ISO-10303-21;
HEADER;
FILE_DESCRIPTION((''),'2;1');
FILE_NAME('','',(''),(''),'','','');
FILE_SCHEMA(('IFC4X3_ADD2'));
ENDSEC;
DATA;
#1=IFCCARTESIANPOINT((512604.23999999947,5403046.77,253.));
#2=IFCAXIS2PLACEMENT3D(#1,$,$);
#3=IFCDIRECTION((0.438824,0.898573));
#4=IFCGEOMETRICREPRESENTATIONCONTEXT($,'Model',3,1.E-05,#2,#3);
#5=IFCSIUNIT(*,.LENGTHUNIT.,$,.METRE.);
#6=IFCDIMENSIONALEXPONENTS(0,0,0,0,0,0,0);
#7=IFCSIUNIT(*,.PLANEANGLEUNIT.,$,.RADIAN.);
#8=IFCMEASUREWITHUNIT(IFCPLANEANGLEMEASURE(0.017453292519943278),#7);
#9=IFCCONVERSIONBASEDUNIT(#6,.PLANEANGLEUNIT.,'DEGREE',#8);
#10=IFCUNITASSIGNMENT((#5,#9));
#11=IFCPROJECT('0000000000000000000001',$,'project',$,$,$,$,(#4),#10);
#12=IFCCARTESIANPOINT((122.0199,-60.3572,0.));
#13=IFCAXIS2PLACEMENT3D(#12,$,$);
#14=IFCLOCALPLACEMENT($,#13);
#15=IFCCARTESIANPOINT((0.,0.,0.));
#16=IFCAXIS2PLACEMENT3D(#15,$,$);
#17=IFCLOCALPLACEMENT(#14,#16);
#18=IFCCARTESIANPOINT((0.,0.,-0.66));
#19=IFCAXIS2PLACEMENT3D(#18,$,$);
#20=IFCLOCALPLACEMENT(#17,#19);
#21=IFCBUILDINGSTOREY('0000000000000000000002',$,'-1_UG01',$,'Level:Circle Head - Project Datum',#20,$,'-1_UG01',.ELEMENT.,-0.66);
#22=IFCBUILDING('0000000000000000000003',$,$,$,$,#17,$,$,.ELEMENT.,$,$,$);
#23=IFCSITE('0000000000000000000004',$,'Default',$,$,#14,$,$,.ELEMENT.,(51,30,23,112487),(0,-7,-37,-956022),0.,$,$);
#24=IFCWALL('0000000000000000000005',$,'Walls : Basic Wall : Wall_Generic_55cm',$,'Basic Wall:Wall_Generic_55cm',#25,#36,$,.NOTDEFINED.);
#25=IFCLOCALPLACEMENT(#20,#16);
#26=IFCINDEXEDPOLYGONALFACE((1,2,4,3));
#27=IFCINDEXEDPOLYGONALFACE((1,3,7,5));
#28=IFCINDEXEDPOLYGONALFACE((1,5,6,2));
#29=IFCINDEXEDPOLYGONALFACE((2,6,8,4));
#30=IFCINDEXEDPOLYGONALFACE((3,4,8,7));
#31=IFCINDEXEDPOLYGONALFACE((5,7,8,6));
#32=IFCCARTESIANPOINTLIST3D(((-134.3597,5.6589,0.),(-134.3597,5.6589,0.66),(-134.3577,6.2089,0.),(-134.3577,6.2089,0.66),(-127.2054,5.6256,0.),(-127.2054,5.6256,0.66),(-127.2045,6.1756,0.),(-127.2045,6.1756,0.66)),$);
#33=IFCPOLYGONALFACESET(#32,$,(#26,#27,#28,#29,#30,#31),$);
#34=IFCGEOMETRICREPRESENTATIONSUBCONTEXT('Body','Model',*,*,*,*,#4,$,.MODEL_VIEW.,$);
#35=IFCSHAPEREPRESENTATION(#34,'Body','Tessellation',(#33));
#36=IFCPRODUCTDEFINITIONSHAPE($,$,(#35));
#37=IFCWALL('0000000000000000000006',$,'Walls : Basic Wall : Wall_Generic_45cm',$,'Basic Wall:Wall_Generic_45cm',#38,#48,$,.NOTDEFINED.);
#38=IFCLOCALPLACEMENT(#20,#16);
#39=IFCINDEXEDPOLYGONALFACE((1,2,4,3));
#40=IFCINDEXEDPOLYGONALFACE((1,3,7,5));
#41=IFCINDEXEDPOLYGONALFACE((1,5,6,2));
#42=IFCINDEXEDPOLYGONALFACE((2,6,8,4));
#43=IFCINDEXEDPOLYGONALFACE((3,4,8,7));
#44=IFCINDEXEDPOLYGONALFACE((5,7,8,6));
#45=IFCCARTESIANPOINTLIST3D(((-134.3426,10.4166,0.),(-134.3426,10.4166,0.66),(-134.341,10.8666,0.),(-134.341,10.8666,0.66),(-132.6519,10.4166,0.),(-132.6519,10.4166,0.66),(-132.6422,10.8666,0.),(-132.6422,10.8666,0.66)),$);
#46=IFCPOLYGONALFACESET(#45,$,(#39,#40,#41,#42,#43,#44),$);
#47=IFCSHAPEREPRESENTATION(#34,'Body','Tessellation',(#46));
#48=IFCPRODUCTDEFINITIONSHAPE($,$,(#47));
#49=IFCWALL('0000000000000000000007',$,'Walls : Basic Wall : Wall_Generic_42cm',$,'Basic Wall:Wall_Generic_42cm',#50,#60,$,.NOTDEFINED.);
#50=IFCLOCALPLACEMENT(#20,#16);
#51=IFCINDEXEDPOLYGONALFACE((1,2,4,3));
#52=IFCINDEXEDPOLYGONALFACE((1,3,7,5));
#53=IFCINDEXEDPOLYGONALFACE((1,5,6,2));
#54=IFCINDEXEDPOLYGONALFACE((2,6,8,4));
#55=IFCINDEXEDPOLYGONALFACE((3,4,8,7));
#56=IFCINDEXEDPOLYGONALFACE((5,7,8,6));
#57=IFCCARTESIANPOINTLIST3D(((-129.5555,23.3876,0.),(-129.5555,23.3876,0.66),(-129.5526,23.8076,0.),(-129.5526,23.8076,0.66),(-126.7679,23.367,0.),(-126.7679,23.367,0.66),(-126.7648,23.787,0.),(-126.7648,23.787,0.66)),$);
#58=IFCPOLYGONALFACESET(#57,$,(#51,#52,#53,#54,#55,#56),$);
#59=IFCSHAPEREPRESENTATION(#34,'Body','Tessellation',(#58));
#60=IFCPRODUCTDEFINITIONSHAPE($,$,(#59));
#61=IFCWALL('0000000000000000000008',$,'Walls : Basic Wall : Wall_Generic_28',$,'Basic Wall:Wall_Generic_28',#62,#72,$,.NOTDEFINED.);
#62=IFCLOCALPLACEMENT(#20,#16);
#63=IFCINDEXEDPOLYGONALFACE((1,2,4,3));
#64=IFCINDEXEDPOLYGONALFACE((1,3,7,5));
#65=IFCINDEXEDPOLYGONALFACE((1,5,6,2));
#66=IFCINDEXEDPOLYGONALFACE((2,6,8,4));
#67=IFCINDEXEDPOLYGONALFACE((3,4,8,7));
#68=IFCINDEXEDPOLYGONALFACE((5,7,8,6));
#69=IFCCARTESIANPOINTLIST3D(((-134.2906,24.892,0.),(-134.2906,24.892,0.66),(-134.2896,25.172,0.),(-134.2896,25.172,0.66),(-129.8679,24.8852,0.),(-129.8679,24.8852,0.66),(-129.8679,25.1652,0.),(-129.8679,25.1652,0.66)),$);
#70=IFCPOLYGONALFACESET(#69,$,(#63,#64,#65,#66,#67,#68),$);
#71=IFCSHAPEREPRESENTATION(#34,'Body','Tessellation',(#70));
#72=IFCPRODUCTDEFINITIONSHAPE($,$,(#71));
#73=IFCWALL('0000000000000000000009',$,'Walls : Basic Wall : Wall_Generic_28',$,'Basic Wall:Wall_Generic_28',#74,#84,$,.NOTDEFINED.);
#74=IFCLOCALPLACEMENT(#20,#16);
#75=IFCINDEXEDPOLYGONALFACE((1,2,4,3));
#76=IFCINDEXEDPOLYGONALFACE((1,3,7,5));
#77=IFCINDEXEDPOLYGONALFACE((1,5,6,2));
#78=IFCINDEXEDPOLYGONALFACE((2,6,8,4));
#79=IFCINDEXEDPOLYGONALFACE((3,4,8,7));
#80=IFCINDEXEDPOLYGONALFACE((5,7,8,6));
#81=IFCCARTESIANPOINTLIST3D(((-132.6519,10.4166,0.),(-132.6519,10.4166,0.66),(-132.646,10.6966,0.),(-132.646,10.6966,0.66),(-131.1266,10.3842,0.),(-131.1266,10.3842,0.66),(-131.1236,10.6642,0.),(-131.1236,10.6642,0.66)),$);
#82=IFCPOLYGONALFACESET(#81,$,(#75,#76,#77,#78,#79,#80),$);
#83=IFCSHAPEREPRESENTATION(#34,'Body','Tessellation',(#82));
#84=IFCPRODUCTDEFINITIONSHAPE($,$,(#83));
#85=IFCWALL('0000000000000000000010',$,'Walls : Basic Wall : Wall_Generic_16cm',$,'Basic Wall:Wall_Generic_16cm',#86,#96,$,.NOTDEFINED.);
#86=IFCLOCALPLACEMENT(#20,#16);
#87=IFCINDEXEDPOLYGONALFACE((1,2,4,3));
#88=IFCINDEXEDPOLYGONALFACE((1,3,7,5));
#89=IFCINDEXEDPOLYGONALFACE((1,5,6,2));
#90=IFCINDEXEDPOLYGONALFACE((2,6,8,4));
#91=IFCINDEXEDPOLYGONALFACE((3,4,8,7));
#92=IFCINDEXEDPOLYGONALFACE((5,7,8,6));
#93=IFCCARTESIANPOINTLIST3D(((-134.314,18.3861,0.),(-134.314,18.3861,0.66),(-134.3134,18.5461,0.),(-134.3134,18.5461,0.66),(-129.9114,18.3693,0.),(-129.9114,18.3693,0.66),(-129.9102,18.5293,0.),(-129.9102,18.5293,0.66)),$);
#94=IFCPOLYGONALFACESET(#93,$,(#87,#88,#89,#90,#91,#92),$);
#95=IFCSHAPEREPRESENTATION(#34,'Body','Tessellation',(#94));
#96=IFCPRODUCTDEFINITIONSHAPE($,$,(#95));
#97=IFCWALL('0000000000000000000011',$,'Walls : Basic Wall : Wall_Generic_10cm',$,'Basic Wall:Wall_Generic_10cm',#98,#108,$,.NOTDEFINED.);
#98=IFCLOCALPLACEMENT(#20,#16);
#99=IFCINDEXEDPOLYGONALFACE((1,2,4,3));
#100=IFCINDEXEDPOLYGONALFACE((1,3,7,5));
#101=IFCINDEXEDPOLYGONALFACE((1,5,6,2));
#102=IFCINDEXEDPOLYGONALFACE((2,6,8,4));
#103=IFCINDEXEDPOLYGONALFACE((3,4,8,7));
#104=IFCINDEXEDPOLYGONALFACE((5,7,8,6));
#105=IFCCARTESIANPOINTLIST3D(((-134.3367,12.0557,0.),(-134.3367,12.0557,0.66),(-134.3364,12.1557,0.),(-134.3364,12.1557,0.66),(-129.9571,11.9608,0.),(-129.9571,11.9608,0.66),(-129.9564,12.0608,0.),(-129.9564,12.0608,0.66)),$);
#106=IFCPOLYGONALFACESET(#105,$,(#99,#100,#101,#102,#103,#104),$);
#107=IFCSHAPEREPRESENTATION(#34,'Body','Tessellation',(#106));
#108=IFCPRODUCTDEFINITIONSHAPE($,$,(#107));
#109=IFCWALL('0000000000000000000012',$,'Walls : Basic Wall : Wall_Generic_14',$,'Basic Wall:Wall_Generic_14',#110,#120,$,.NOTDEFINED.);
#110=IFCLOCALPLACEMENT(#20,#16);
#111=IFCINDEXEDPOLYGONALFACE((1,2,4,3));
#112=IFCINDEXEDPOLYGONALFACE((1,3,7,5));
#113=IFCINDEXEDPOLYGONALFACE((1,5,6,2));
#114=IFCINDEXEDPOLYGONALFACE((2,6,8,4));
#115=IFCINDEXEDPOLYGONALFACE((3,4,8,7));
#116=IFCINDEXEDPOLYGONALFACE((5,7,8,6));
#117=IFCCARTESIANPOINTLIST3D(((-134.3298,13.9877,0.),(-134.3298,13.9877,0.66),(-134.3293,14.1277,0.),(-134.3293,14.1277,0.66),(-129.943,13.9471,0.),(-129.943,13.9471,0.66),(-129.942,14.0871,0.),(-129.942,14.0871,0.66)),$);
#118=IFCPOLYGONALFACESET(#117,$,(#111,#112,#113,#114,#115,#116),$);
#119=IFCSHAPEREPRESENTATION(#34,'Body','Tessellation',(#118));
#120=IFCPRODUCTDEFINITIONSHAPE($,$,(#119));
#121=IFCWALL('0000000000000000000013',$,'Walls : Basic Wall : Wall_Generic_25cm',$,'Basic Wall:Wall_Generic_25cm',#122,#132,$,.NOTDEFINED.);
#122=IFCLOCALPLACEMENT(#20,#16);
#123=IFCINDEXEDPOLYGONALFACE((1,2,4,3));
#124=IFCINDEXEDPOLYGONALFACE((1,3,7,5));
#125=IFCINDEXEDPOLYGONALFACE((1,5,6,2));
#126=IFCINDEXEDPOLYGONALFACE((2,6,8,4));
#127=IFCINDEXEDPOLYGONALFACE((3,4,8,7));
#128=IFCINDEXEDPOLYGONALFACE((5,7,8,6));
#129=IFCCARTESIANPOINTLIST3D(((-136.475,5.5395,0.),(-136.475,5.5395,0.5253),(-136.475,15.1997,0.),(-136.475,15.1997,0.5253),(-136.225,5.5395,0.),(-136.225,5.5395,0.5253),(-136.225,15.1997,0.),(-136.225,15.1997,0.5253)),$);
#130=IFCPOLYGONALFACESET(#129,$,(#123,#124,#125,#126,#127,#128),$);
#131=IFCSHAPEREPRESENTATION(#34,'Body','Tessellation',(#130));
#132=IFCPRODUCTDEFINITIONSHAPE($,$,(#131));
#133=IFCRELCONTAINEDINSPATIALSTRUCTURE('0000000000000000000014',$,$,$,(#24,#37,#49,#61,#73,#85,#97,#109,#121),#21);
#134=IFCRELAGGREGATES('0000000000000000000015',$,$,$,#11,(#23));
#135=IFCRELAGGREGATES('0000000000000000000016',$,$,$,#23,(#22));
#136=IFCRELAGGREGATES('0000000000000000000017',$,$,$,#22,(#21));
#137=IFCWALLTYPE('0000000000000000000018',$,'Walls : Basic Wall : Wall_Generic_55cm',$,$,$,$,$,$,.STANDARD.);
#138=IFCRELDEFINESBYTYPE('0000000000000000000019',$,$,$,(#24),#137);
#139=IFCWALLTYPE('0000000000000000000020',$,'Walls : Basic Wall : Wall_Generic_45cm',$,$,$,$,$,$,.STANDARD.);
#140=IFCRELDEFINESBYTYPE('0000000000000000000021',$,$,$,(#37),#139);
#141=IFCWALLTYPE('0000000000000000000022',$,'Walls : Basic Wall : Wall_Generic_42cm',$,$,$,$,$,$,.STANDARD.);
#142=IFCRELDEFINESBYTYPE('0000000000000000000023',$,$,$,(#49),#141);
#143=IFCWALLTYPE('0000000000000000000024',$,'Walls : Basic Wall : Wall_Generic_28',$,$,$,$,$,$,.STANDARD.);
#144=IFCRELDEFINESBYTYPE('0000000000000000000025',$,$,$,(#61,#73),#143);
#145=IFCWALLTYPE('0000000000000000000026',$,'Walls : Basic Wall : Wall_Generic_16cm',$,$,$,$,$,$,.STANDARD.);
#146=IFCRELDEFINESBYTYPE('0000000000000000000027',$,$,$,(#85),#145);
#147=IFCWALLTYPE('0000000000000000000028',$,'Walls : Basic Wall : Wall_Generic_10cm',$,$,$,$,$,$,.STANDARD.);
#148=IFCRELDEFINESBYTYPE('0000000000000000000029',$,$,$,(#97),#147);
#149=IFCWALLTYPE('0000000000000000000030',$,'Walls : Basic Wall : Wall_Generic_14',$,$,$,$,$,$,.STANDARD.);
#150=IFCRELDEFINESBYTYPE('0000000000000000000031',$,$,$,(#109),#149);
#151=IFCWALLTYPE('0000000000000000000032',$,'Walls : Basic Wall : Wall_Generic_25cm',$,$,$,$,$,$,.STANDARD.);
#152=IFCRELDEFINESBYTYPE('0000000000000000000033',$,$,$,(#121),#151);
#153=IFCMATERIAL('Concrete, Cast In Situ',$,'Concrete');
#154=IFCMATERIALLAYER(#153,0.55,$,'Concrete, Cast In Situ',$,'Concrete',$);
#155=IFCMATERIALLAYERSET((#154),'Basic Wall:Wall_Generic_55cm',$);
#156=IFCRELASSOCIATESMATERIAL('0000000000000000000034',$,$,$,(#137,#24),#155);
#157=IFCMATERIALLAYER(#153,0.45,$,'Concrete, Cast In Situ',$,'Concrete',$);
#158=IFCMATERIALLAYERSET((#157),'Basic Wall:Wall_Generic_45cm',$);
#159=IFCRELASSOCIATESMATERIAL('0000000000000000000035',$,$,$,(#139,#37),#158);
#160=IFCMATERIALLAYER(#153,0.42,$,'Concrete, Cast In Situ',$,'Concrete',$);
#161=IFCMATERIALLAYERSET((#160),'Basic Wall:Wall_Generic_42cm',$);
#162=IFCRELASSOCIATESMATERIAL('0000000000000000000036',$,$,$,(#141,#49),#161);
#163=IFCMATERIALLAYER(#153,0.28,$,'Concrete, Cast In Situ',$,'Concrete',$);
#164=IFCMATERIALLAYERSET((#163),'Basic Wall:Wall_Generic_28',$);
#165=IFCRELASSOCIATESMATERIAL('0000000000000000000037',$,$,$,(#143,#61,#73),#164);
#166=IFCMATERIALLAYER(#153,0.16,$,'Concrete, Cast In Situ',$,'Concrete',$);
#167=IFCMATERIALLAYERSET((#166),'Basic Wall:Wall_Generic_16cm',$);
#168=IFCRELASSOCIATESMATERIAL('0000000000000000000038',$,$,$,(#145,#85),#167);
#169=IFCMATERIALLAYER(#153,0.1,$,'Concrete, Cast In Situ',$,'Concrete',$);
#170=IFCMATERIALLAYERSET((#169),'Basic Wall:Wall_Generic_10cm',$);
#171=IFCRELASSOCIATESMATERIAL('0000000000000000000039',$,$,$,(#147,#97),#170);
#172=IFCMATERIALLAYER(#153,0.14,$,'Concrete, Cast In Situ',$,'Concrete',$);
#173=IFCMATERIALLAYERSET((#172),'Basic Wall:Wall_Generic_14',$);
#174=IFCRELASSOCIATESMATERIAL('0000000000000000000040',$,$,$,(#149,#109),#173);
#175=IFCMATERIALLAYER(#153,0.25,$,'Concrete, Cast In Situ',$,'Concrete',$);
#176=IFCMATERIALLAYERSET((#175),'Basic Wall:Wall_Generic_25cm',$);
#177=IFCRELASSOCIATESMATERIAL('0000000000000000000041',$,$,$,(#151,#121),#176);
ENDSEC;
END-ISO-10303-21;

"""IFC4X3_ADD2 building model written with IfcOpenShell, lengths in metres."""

from ifc_helpers import new_model, entity, si_unit, converted_unit, direction, frame, frame_2d, origin, place, context, subcontext, project, spatial, polyline, rectangle, outline, extrude, clip, halfspace, material, layer, layer_set, type_object, element, save


model = new_model("IFC4X3_ADD2")

# Units and contexts
model_context = context("Model", 3, precision=1e-05, world=frame((512604.23999999947, 5403046.77, 253.0)), true_north=direction((0.438824, 0.898573)))
body_context = subcontext(model_context, "Body", "Model", "MODEL_VIEW")
ifc_project = project(units=[si_unit("LENGTHUNIT", "METRE"), converted_unit("PLANEANGLEUNIT", "DEGREE", entity("IfcPlaneAngleMeasure", 0.017453292519943278), si_unit("PLANEANGLEUNIT", "RADIAN"), dimensions=[0, 0, 0, 0, 0, 0, 0])], contexts=[model_context])

# Site, building, storey
site_placement = place(None, frame((122.0199, -60.3572, 0.0)))
site = spatial("IfcSite", under=ifc_project, at=site_placement, Name="Default", CompositionType="ELEMENT", RefLatitude=(51, 30, 23, 112487), RefLongitude=(0, -7, -37, -956022), RefElevation=0.0)
building_placement = place(site_placement, origin())
building = spatial("IfcBuilding", under=site, at=building_placement, CompositionType="ELEMENT")
storey_placement = place(building_placement, frame((0.0, 0.0, -0.66)))
storey = spatial("IfcBuildingStorey", under=building, at=storey_placement, Name="-1_UG01", ObjectType="Level:Circle Head - Project Datum", LongName="-1_UG01", CompositionType="ELEMENT", Elevation=-0.66)

# Walls
ifc_material_1 = material(Name="Concrete, Cast In Situ", Category="Concrete")
ifc_layer_1 = layer(ifc_material_1, 0.55, Name="Concrete, Cast In Situ", Category="Concrete")
ifc_layer_set_1 = layer_set([ifc_layer_1], Name="Basic Wall:Wall_Generic_55cm")
wall_type_1 = type_object("IfcWallType", Name="Walls : Basic Wall : Wall_Generic_55cm", PredefinedType="STANDARD", material=ifc_layer_set_1)
wall_1_placement = place(storey_placement, frame((-134.359, 5.9339, 0.0), z_axis=(0.0, 0.0, 1.0), x_axis=(0.999989, -0.004647, 0.0)))
element("IfcWall", 1, at=wall_1_placement, inside=storey, type_object=wall_type_1, material=ifc_layer_set_1, Name="Walls : Basic Wall : Wall_Generic_55cm", ObjectType="Basic Wall:Wall_Generic_55cm", PredefinedType="NOTDEFINED", context=body_context, shape_type="Clipping", body=[
    clip(extrude(outline(polyline([(7.155, -0.275), (7.1533, 0.275), (0.0, 0.275), (0.0006, -0.275), (7.155, -0.275)])), origin(), (0.0, 0.0, 1.0), 0.66), halfspace(origin(), True)),
])
ifc_layer_2 = layer(ifc_material_1, 0.45, Name="Concrete, Cast In Situ", Category="Concrete")
ifc_layer_set_2 = layer_set([ifc_layer_2], Name="Basic Wall:Wall_Generic_45cm")
wall_type_2 = type_object("IfcWallType", Name="Walls : Basic Wall : Wall_Generic_45cm", PredefinedType="STANDARD", material=ifc_layer_set_2)
wall_2_placement = place(storey_placement, frame((-134.3426, 10.6416, 0.0)))
element("IfcWall", 2, at=wall_2_placement, inside=storey, type_object=wall_type_2, material=ifc_layer_set_2, Name="Walls : Basic Wall : Wall_Generic_45cm", ObjectType="Basic Wall:Wall_Generic_45cm", PredefinedType="NOTDEFINED", context=body_context, shape_type="Clipping", body=[
    clip(extrude(outline(polyline([(1.6907, -0.225), (1.6968, 0.0549), (1.7004, 0.225), (1.6604, 0.225), (0.0016, 0.225), (0.0, -0.225), (1.6327, -0.225), (1.6727, -0.225), (1.6907, -0.225)])), origin(), (0.0, 0.0, 1.0), 0.66), halfspace(origin(), True)),
])
ifc_layer_3 = layer(ifc_material_1, 0.42, Name="Concrete, Cast In Situ", Category="Concrete")
ifc_layer_set_3 = layer_set([ifc_layer_3], Name="Basic Wall:Wall_Generic_42cm")
wall_type_3 = type_object("IfcWallType", Name="Walls : Basic Wall : Wall_Generic_42cm", PredefinedType="STANDARD", material=ifc_layer_set_3)
wall_3_placement = place(storey_placement, frame((-129.5541, 23.5976, 0.0), z_axis=(0.0, 0.0, 1.0), x_axis=(0.999973, -0.007398, 0.0)))
element("IfcWall", 3, at=wall_3_placement, inside=storey, type_object=wall_type_3, material=ifc_layer_set_3, Name="Walls : Basic Wall : Wall_Generic_42cm", ObjectType="Basic Wall:Wall_Generic_42cm", PredefinedType="NOTDEFINED", context=body_context, shape_type="Clipping", body=[
    clip(extrude(outline(polyline([(2.7879, -0.21), (2.7879, 0.21), (2.309, 0.21), (0.0, 0.21), (0.0001, -0.21), (2.3679, -0.21), (2.7879, -0.21)])), origin(), (0.0, 0.0, 1.0), 0.66), halfspace(origin(), True)),
])
ifc_layer_4 = layer(ifc_material_1, 0.28, Name="Concrete, Cast In Situ", Category="Concrete")
ifc_layer_set_4 = layer_set([ifc_layer_4], Name="Basic Wall:Wall_Generic_28")
wall_type_4 = type_object("IfcWallType", Name="Walls : Basic Wall : Wall_Generic_28", PredefinedType="STANDARD", material=ifc_layer_set_4)
wall_4_placement = place(storey_placement, frame((-134.2904, 25.032, 0.0), z_axis=(0.0, 0.0, 1.0), x_axis=(0.999999, -0.001547, 0.0)))
element("IfcWall", 4, at=wall_4_placement, inside=storey, type_object=wall_type_4, material=ifc_layer_set_4, Name="Walls : Basic Wall : Wall_Generic_28", ObjectType="Basic Wall:Wall_Generic_28", PredefinedType="NOTDEFINED", context=body_context, shape_type="Clipping", body=[
    clip(extrude(outline(polyline([(4.4228, -0.14), (4.4223, 0.14), (4.342, 0.14), (0.0006, 0.14), (0.0, -0.14), (4.4228, -0.14)])), origin(), (0.0, 0.0, 1.0), 0.66), halfspace(origin(), True)),
])
wall_5_placement = place(storey_placement, frame((-132.6489, 10.5566, 0.0), z_axis=(0.0, 0.0, 1.0), x_axis=(0.999774, -0.021241, 0.0)))
element("IfcWall", 5, at=wall_5_placement, inside=storey, type_object=wall_type_4, material=ifc_layer_set_4, Name="Walls : Basic Wall : Wall_Generic_28", ObjectType="Basic Wall:Wall_Generic_28", PredefinedType="NOTDEFINED", context=body_context, shape_type="Clipping", body=[
    clip(extrude(outline(polyline([(1.5256, -0.14), (1.5227, 0.14), (0.0, 0.14), (0.0, -0.14), (1.5256, -0.14)])), origin(), (0.0, 0.0, 1.0), 0.66), halfspace(origin(), True)),
])
ifc_layer_5 = layer(ifc_material_1, 0.16, Name="Concrete, Cast In Situ", Category="Concrete")
ifc_layer_set_5 = layer_set([ifc_layer_5], Name="Basic Wall:Wall_Generic_16cm")
wall_type_5 = type_object("IfcWallType", Name="Walls : Basic Wall : Wall_Generic_16cm", PredefinedType="STANDARD", material=ifc_layer_set_5)
wall_6_placement = place(storey_placement, frame((-129.9105, 18.4493, 0.0), z_axis=(0.0, 0.0, 1.0), x_axis=(-0.999993, 0.003818, 0.0)))
element("IfcWall", 6, at=wall_6_placement, inside=storey, type_object=wall_type_5, material=ifc_layer_set_5, Name="Walls : Basic Wall : Wall_Generic_16cm", ObjectType="Basic Wall:Wall_Generic_16cm", PredefinedType="NOTDEFINED", context=body_context, shape_type="Clipping", body=[
    clip(extrude(outline(polyline([(4.4032, -0.08), (4.4032, 0.08), (0.0005, 0.08), (0.0, -0.08), (4.4032, -0.08)])), origin(), (0.0, 0.0, 1.0), 0.66), halfspace(origin(), True)),
])
ifc_layer_6 = layer(ifc_material_1, 0.1, Name="Concrete, Cast In Situ", Category="Concrete")
ifc_layer_set_6 = layer_set([ifc_layer_6], Name="Basic Wall:Wall_Generic_10cm")
wall_type_6 = type_object("IfcWallType", Name="Walls : Basic Wall : Wall_Generic_10cm", PredefinedType="STANDARD", material=ifc_layer_set_6)
wall_7_placement = place(storey_placement, frame((-134.3374, 12.1057, 0.0), z_axis=(0.0, 0.0, 1.0), x_axis=(0.999765, -0.021666, 0.0)))
element("IfcWall", 7, at=wall_7_placement, inside=storey, type_object=wall_type_6, material=ifc_layer_set_6, Name="Walls : Basic Wall : Wall_Generic_10cm", ObjectType="Basic Wall:Wall_Generic_10cm", PredefinedType="NOTDEFINED", context=body_context, shape_type="Clipping", body=[
    clip(extrude(outline(polyline([(4.3824, -0.05), (4.381, 0.05), (0.0, 0.05), (0.0018, -0.05), (1.6817, -0.05), (1.7217, -0.05), (3.2301, -0.05), (3.3701, -0.05), (4.3824, -0.05)])), origin(), (0.0, 0.0, 1.0), 0.66), halfspace(origin(), True)),
])
ifc_layer_7 = layer(ifc_material_1, 0.14, Name="Concrete, Cast In Situ", Category="Concrete")
ifc_layer_set_7 = layer_set([ifc_layer_7], Name="Basic Wall:Wall_Generic_14")
wall_type_7 = type_object("IfcWallType", Name="Walls : Basic Wall : Wall_Generic_14", PredefinedType="STANDARD", material=ifc_layer_set_7)
wall_8_placement = place(storey_placement, frame((-129.9423, 14.0171, 0.0), z_axis=(0.0, 0.0, 1.0), x_axis=(-0.999957, 0.009259, 0.0)))
element("IfcWall", 8, at=wall_8_placement, inside=storey, type_object=wall_type_7, material=ifc_layer_set_7, Name="Walls : Basic Wall : Wall_Generic_14", ObjectType="Basic Wall:Wall_Generic_14", PredefinedType="NOTDEFINED", context=body_context, shape_type="Clipping", body=[
    clip(extrude(outline(polyline([(4.3878, -0.07), (4.387, 0.07), (0.0, 0.07), (0.0003, -0.07), (4.3878, -0.07)])), origin(), (0.0, 0.0, 1.0), 0.66), halfspace(origin(), True)),
])
ifc_layer_8 = layer(ifc_material_1, 0.25, Name="Concrete, Cast In Situ", Category="Concrete")
ifc_layer_set_8 = layer_set([ifc_layer_8], Name="Basic Wall:Wall_Generic_25cm")
wall_type_8 = type_object("IfcWallType", Name="Walls : Basic Wall : Wall_Generic_25cm", PredefinedType="STANDARD", material=ifc_layer_set_8)
wall_9_placement = place(storey_placement, frame((-136.35, 5.5395, 0.0), z_axis=(0.0, 0.0, 1.0), x_axis=(0.0, 1.0, 0.0)))
element("IfcWall", 9, at=wall_9_placement, inside=storey, type_object=wall_type_8, material=ifc_layer_set_8, Name="Walls : Basic Wall : Wall_Generic_25cm", ObjectType="Basic Wall:Wall_Generic_25cm", PredefinedType="NOTDEFINED", context=body_context, shape_type="Clipping", body=[
    clip(extrude(rectangle(XDim=9.6601, YDim=0.25, at=frame_2d((4.8301, 0.0), x_axis=(-1.0, 0.0))), origin(), (0.0, 0.0, 1.0), 0.5253), halfspace(frame((0.0, 0.0, -1.5797)), True)),
])

save(model, "model.ifc")
